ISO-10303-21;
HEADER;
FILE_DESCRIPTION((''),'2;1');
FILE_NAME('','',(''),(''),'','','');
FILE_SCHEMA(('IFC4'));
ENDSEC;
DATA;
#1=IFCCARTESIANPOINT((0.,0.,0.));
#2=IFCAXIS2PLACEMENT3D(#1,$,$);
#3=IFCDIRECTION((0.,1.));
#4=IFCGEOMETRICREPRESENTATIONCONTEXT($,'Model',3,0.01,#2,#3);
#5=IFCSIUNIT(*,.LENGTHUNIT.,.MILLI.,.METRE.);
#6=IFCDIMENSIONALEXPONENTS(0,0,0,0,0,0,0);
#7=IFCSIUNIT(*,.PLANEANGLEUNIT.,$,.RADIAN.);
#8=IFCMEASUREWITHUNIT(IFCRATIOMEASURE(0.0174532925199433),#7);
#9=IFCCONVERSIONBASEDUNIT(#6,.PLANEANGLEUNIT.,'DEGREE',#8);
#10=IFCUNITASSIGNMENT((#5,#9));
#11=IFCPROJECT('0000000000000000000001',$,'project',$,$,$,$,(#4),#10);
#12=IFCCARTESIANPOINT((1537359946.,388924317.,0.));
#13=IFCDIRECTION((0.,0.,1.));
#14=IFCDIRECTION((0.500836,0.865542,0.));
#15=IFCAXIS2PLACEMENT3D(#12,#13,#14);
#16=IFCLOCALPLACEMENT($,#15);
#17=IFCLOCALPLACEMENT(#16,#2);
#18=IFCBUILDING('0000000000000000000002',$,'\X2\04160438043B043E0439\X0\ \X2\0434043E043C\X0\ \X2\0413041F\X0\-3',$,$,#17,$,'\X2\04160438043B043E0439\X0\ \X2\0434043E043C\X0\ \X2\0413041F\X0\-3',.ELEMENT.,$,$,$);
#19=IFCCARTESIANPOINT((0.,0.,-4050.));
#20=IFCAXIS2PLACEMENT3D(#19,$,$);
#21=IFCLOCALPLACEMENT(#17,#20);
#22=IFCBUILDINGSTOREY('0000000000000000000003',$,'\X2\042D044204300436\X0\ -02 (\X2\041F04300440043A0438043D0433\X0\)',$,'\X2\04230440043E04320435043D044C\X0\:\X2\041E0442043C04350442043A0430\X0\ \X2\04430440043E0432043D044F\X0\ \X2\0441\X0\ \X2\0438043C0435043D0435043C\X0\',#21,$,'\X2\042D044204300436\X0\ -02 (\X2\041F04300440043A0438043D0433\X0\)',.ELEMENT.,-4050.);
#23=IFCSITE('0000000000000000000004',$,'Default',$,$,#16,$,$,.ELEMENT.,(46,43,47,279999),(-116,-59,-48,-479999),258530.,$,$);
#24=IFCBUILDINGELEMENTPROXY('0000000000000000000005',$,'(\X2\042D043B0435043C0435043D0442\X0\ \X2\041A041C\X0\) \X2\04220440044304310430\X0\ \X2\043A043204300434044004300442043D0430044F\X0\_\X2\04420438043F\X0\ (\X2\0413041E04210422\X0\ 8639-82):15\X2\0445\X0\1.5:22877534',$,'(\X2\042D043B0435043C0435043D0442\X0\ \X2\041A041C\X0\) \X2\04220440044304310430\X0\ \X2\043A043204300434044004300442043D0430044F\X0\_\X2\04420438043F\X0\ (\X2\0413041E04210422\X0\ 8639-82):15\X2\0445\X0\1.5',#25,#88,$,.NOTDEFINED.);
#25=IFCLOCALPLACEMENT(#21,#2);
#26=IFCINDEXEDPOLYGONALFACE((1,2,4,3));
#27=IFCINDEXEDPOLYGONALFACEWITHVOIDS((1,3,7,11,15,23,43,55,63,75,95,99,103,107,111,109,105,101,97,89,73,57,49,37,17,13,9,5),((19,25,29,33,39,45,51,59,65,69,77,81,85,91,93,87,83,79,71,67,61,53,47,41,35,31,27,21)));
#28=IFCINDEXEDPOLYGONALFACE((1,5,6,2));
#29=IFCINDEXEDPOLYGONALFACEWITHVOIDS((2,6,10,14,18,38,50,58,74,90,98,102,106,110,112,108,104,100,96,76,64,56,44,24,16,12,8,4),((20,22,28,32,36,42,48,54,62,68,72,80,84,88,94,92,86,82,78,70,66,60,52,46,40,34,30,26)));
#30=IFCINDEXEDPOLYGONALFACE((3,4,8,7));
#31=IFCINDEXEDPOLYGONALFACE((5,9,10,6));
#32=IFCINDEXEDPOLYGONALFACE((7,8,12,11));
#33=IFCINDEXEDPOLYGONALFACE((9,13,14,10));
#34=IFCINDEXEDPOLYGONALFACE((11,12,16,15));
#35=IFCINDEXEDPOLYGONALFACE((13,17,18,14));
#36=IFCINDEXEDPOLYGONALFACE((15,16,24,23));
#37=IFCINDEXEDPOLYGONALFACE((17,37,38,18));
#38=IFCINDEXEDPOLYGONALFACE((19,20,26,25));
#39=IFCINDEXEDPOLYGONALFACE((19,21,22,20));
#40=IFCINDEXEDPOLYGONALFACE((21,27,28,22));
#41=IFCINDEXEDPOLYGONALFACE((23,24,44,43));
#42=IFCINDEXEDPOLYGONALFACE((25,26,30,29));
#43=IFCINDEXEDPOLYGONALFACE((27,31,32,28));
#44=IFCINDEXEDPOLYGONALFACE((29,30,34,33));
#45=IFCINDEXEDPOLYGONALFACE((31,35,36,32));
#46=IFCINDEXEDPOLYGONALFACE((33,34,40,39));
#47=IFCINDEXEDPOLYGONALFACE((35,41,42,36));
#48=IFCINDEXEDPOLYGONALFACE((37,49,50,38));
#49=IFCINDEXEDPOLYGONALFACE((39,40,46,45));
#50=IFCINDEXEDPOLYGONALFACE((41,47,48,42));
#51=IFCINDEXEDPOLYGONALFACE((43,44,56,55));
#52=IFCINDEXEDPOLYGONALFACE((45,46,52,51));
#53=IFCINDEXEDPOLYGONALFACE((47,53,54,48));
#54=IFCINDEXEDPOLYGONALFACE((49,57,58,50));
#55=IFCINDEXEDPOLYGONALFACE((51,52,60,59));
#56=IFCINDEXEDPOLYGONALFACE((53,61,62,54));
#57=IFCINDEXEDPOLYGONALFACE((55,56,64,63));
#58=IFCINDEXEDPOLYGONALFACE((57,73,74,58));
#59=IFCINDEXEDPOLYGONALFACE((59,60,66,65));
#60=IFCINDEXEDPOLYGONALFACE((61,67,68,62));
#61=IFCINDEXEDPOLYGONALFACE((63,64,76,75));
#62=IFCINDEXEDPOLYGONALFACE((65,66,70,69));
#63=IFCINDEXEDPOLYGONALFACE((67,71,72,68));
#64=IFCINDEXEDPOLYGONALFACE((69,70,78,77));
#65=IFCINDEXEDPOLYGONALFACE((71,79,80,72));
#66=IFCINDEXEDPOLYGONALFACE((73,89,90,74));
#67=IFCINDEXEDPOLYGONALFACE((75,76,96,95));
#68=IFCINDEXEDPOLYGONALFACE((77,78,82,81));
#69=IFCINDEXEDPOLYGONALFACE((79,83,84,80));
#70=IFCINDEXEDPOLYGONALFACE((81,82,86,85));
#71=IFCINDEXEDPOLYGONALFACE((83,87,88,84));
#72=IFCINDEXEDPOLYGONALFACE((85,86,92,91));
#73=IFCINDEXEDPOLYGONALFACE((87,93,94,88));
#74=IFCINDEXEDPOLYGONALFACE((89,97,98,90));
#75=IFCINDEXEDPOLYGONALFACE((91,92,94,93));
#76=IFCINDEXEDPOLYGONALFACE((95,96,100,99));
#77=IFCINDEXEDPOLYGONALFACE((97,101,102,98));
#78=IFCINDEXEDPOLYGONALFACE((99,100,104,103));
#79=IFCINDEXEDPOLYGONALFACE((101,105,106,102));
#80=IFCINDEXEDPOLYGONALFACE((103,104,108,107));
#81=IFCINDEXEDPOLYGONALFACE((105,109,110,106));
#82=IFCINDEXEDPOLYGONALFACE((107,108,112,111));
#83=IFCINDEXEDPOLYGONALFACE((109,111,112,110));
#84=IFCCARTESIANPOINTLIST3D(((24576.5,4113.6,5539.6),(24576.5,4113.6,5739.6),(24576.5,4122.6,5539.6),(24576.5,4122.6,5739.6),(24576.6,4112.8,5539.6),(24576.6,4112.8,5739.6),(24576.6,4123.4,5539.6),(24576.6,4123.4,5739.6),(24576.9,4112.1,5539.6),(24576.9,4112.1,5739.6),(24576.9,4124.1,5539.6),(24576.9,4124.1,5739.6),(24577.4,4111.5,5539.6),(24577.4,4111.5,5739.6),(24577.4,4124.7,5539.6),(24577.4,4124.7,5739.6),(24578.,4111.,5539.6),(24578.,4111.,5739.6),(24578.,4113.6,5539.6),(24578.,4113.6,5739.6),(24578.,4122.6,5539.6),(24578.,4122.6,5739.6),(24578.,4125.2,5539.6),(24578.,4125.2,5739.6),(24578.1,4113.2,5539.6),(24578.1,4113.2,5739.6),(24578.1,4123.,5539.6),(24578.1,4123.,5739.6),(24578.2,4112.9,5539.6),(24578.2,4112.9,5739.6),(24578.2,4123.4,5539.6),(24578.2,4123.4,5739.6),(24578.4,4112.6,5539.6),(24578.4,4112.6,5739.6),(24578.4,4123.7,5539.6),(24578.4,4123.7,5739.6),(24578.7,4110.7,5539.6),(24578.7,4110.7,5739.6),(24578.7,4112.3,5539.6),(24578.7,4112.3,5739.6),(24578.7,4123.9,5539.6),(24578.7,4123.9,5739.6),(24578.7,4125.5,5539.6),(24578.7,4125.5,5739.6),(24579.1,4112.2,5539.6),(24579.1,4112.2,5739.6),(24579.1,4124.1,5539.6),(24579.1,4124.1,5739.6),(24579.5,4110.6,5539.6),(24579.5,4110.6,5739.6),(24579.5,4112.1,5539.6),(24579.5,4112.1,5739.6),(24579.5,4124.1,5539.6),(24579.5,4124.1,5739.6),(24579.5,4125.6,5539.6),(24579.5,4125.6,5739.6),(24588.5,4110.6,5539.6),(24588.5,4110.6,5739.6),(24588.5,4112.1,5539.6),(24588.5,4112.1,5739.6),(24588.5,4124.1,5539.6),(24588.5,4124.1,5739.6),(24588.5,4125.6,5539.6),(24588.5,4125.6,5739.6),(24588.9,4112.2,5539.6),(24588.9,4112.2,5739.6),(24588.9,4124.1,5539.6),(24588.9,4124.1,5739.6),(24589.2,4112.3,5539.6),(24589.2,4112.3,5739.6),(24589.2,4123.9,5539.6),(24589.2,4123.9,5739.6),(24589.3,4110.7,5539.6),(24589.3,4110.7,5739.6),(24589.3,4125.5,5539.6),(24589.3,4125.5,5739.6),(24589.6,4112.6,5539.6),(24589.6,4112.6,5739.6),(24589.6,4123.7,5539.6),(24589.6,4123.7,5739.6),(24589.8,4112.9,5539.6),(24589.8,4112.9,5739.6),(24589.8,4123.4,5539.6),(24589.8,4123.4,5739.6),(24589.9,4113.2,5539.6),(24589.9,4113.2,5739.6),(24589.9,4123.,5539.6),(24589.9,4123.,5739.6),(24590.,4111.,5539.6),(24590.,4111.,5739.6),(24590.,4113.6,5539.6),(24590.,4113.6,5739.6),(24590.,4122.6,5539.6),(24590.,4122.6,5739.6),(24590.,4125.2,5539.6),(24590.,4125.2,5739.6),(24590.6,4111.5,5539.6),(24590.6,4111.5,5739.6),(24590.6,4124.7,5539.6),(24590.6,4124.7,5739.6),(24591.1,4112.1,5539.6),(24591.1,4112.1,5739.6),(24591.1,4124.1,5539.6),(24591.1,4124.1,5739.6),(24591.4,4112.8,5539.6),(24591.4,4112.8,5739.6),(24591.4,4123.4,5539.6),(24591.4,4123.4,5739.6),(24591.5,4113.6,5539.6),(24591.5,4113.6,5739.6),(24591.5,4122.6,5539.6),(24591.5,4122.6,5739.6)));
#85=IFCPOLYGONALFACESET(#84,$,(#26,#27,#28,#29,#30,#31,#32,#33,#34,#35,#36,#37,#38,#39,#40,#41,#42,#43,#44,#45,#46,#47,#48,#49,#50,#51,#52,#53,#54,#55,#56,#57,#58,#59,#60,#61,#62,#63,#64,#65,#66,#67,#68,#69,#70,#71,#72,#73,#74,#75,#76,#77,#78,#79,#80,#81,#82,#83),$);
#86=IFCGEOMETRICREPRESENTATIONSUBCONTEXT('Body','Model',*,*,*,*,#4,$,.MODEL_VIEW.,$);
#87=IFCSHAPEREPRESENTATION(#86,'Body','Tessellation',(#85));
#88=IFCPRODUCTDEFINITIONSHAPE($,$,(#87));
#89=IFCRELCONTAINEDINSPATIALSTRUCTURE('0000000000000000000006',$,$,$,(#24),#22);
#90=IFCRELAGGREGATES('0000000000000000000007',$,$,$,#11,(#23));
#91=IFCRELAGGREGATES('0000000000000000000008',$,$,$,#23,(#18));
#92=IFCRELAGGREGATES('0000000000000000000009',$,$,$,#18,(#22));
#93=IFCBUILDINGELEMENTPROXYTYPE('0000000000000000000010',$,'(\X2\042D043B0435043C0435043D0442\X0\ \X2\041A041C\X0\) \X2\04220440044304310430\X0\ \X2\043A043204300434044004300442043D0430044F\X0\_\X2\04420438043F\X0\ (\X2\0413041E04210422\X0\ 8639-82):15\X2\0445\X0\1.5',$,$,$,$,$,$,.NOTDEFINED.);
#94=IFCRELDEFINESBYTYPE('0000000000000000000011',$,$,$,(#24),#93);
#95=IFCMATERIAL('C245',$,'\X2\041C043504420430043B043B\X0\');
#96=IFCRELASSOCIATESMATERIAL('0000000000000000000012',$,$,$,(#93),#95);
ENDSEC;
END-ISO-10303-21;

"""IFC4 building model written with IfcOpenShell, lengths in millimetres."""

from ifc_helpers import new_model, entity, si_unit, converted_unit, direction, frame, frame_2d, origin, place, context, subcontext, project, spatial, polyline, circle_curve, parameter, trimmed, segment, composite_curve, outline, extrude, source, transform, mapped, material, type_object, type_shapes, element, save


model = new_model("IFC4")

# Units and contexts
model_context = context("Model", 3, precision=0.01, world=origin(), true_north=direction((0.0, 1.0)))
body_context = subcontext(model_context, "Body", "Model", "MODEL_VIEW")
ifc_project = project(units=[si_unit("LENGTHUNIT", "METRE", prefix="MILLI"), converted_unit("PLANEANGLEUNIT", "DEGREE", entity("IfcRatioMeasure", 0.0174532925199433), si_unit("PLANEANGLEUNIT", "RADIAN"), dimensions=[0, 0, 0, 0, 0, 0, 0])], contexts=[model_context])

# Site, building, storey
site_placement = place(None, frame((1537359946.0, 388924317.0, 0.0), z_axis=(0.0, 0.0, 1.0), x_axis=(0.500836, 0.865542, 0.0)))
site = spatial("IfcSite", under=ifc_project, at=site_placement, Name="Default", CompositionType="ELEMENT", RefLatitude=(46, 43, 47, 279999), RefLongitude=(-116, -59, -48, -479999), RefElevation=258530.0)
building_placement = place(site_placement, origin())
building = spatial("IfcBuilding", under=site, at=building_placement, Name="Жилой дом ГП-3", LongName="Жилой дом ГП-3", CompositionType="ELEMENT")
storey_placement = place(building_placement, frame((0.0, 0.0, -4050.0)))
storey = spatial("IfcBuildingStorey", under=building, at=storey_placement, Name="Этаж -02 (Паркинг)", ObjectType="Уровень:Отметка уровня с именем", LongName="Этаж -02 (Паркинг)", CompositionType="ELEMENT", Elevation=-4050.0)

# Building element proxy
ifc_material_1 = material(Name="C245", Category="Металл")
building_element_proxy_type_1 = type_object("IfcBuildingElementProxyType", Name="(Элемент КМ) Труба квадратная_тип (ГОСТ 8639-82):15х1.5", PredefinedType="NOTDEFINED", material=ifc_material_1)
shared_shape_1 = source(origin(), body_context, "Body", "SweptSolid", [
    extrude(outline(composite_curve([segment(trimmed(circle_curve(frame_2d((4.5, -4.5), x_axis=(1.0, 0.0)), 3.0), [parameter(270.0)], [parameter(0.0)], True, "PARAMETER"), True, "CONTINUOUS"), segment(polyline([(7.5, -4.5), (7.5, 4.5)]), True, "CONTINUOUS"), segment(trimmed(circle_curve(frame_2d((4.5, 4.5), x_axis=(1.0, 0.0)), 3.0), [parameter(0.0)], [parameter(90.0)], True, "PARAMETER"), True, "CONTINUOUS"), segment(polyline([(4.5, 7.5), (-4.5, 7.5)]), True, "CONTINUOUS"), segment(trimmed(circle_curve(frame_2d((-4.5, 4.5), x_axis=(1.0, 0.0)), 3.0), [parameter(90.0)], [parameter(180.0)], True, "PARAMETER"), True, "CONTINUOUS"), segment(polyline([(-7.5, 4.5), (-7.5, -4.5)]), True, "CONTINUOUS"), segment(trimmed(circle_curve(frame_2d((-4.5, -4.5), x_axis=(1.0, 0.0)), 3.0), [parameter(180.0)], [parameter(270.0)], True, "PARAMETER"), True, "CONTINUOUS"), segment(polyline([(-4.5, -7.5), (4.5, -7.5)]), True, "CONTINUOUS")], self_intersect=False), holes=[composite_curve([segment(polyline([(4.5, -6.0), (-4.5, -6.0)]), True, "CONTINUOUS"), segment(trimmed(circle_curve(frame_2d((-4.5, -4.5), x_axis=(1.0, 0.0)), 1.5), [parameter(180.0)], [parameter(270.0)], True, "PARAMETER"), False, "CONTINUOUS"), segment(polyline([(-6.0, -4.5), (-6.0, 4.5)]), True, "CONTINUOUS"), segment(trimmed(circle_curve(frame_2d((-4.5, 4.5), x_axis=(1.0, 0.0)), 1.5), [parameter(90.0)], [parameter(180.0)], True, "PARAMETER"), False, "CONTINUOUS"), segment(polyline([(-4.5, 6.0), (4.5, 6.0)]), True, "CONTINUOUS"), segment(trimmed(circle_curve(frame_2d((4.5, 4.5), x_axis=(1.0, 0.0)), 1.5), [parameter(0.0)], [parameter(90.0)], True, "PARAMETER"), False, "CONTINUOUS"), segment(polyline([(6.0, 4.5), (6.0, -4.5)]), True, "CONTINUOUS"), segment(trimmed(circle_curve(frame_2d((4.5, -4.5), x_axis=(1.0, 0.0)), 1.5), [parameter(270.0)], [parameter(0.0)], True, "PARAMETER"), False, "CONTINUOUS")], self_intersect=False)]), frame((-100.0, 0.0, 0.0), z_axis=(1.0, 0.0, 0.0), x_axis=(0.0, -1.0, 0.0)), (0.0, 0.0, 1.0), 200.0),
])
type_shapes(building_element_proxy_type_1, [shared_shape_1])
for number, where, z_axis, x_axis, name in (
    (1, (24584.0, 4118.1, 5639.6), (1.0, 0.0, 0.0), (0.0, 0.0, 1.0), "(Элемент КМ) Труба квадратная_тип (ГОСТ 8639-82):15х1.5:22877534"),
):
    element("IfcBuildingElementProxy", number, at=place(storey_placement, frame(where, z_axis=z_axis, x_axis=x_axis)), inside=storey, type_object=building_element_proxy_type_1, Name=name, ObjectType="(Элемент КМ) Труба квадратная_тип (ГОСТ 8639-82):15х1.5", PredefinedType="NOTDEFINED", context=body_context, shape_type="MappedRepresentation", body=[
        mapped(shared_shape_1, transform((0.0, 0.0, 0.0), scale=1.0)),
    ])

save(model, "model.ifc")
